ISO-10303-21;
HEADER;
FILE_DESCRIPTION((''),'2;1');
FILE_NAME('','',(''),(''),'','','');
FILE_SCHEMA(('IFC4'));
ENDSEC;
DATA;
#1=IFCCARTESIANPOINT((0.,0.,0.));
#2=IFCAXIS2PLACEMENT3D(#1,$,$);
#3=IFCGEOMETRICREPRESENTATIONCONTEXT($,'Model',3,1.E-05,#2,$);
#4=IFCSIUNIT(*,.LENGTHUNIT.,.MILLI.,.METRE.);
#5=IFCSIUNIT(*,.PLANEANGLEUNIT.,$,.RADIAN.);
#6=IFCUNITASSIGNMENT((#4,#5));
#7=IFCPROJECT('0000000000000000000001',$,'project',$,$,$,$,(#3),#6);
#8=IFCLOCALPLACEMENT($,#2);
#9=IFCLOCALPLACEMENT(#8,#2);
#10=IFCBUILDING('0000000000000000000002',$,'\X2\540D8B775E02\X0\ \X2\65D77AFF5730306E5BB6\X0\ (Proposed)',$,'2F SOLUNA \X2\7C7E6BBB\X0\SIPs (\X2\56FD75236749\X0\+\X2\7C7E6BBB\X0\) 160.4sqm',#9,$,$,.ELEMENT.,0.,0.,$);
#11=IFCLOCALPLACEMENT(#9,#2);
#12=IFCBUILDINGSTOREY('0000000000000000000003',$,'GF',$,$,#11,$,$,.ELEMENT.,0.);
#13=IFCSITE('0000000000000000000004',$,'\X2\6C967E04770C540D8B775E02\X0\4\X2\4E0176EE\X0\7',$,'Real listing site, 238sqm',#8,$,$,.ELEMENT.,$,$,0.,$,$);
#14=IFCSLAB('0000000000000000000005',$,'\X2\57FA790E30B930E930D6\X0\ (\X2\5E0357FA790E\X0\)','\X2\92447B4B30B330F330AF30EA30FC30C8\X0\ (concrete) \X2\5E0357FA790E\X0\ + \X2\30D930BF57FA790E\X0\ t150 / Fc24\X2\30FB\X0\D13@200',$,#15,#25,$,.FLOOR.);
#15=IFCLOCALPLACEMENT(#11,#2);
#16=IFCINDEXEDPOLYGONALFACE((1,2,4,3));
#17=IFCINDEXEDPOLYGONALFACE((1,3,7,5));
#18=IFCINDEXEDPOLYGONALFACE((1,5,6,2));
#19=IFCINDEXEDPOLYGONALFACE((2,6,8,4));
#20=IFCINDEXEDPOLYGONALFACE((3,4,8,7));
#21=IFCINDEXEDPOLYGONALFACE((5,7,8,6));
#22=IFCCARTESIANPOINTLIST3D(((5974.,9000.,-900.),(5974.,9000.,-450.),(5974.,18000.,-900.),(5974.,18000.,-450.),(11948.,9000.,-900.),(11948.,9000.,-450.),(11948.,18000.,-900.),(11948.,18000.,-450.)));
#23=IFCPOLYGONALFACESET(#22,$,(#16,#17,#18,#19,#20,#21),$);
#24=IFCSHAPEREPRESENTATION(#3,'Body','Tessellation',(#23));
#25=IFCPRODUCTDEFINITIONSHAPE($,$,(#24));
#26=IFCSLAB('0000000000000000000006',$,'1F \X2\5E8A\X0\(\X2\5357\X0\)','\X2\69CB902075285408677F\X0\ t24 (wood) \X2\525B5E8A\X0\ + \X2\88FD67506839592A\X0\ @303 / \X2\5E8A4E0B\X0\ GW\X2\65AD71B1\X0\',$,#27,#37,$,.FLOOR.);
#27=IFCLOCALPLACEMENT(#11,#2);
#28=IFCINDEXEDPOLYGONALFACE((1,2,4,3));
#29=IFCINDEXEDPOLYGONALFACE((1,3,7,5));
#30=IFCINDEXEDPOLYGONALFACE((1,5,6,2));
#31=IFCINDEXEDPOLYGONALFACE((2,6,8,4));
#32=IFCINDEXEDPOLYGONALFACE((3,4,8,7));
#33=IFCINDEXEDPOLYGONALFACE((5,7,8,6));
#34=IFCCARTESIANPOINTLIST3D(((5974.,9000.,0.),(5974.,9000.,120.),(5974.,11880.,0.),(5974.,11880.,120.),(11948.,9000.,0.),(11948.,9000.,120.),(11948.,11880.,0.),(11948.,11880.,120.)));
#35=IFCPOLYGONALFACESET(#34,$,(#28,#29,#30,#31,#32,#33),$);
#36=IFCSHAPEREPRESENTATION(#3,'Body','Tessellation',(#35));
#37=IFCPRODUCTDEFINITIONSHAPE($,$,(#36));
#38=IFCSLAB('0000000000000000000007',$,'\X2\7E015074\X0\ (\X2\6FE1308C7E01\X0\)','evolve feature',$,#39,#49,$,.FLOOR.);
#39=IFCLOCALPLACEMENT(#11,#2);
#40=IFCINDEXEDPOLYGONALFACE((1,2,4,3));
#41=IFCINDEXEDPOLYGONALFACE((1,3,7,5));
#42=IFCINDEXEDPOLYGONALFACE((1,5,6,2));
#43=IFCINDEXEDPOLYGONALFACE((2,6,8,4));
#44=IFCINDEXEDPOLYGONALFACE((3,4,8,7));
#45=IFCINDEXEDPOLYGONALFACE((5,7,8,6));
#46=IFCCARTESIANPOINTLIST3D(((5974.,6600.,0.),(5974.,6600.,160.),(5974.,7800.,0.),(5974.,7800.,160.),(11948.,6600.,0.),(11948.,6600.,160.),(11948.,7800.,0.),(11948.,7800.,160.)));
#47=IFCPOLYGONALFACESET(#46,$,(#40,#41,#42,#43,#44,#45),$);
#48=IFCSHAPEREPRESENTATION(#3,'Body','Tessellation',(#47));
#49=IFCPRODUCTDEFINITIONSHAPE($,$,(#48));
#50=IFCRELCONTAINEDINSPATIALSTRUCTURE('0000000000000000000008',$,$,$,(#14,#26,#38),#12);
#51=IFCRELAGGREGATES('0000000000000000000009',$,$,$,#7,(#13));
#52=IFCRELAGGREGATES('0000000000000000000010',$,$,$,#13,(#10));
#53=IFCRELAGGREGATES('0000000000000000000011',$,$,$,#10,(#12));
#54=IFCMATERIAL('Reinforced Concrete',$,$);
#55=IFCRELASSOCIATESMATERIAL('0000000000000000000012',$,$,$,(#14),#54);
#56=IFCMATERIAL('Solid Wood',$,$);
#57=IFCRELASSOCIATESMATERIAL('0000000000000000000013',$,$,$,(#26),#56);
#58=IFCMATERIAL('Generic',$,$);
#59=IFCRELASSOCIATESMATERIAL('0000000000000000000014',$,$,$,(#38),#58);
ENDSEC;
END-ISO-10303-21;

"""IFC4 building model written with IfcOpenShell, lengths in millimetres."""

from ifc_helpers import new_model, si_unit, frame, frame_2d, origin, place, context, project, spatial, rectangle, extrude, material, element, save


model = new_model("IFC4")

# Units and contexts
model_context = context("Model", 3, precision=1e-05, world=origin())
ifc_project = project(units=[si_unit("LENGTHUNIT", "METRE", prefix="MILLI"), si_unit("PLANEANGLEUNIT", "RADIAN")], contexts=[model_context])

# Site, building, storey
site_placement = place(None, origin())
site = spatial("IfcSite", under=ifc_project, at=site_placement, Name="沖縄県名護市4丁目7", ObjectType="Real listing site, 238sqm", CompositionType="ELEMENT", RefElevation=0.0)
building_placement = place(site_placement, origin())
building = spatial("IfcBuilding", under=site, at=building_placement, Name="名護市 旗竿地の家 (Proposed)", ObjectType="2F SOLUNA 籾殻SIPs (国産杉+籾殻) 160.4sqm", CompositionType="ELEMENT", ElevationOfRefHeight=0.0, ElevationOfTerrain=0.0)
storey_placement = place(building_placement, origin())
storey = spatial("IfcBuildingStorey", under=building, at=storey_placement, Name="GF", CompositionType="ELEMENT", Elevation=0.0)

# Slabs
ifc_material_1 = material(Name="Reinforced Concrete")
slab_1_placement = place(storey_placement, frame((2987.0, 4500.0, -450.0)))
element("IfcSlab", 1, at=slab_1_placement, inside=storey, material=ifc_material_1, Name="基礎スラブ (布基礎)", Description="鉄筋コンクリート (concrete) 布基礎 + ベタ基礎 t150 / Fc24・D13@200", PredefinedType="FLOOR", context=model_context, shape_type="SweptSolid", body=[
    extrude(rectangle(XDim=5974.0, YDim=9000.0, at=frame_2d((2987.0, 4500.0))), frame((2987.0, 4500.0, -450.0)), (0.0, 0.0, 1.0), 450.0),
])
ifc_material_2 = material(Name="Solid Wood")
slab_2_placement = place(storey_placement, frame((2987.0, 4500.0, 0.0)))
element("IfcSlab", 2, at=slab_2_placement, inside=storey, material=ifc_material_2, Name="1F 床(南)", Description="構造用合板 t24 (wood) 剛床 + 製材根太 @303 / 床下 GW断熱", PredefinedType="FLOOR", context=model_context, shape_type="SweptSolid", body=[
    extrude(rectangle(XDim=5974.0, YDim=2880.0, at=frame_2d((2987.0, 1440.0))), frame((2987.0, 4500.0, 0.0)), (0.0, 0.0, 1.0), 120.0),
])
ifc_material_3 = material(Name="Generic")
slab_3_placement = place(storey_placement, frame((2987.0, 3300.0, 0.0)))
element("IfcSlab", 3, at=slab_3_placement, inside=storey, material=ifc_material_3, Name="縁側 (濡れ縁)", Description="evolve feature", PredefinedType="FLOOR", context=model_context, shape_type="SweptSolid", body=[
    extrude(rectangle(XDim=5974.0, YDim=1200.0, at=frame_2d((2987.0, 600.0))), frame((2987.0, 3300.0, 0.0)), (0.0, 0.0, 1.0), 160.0),
])

save(model, "model.ifc")
